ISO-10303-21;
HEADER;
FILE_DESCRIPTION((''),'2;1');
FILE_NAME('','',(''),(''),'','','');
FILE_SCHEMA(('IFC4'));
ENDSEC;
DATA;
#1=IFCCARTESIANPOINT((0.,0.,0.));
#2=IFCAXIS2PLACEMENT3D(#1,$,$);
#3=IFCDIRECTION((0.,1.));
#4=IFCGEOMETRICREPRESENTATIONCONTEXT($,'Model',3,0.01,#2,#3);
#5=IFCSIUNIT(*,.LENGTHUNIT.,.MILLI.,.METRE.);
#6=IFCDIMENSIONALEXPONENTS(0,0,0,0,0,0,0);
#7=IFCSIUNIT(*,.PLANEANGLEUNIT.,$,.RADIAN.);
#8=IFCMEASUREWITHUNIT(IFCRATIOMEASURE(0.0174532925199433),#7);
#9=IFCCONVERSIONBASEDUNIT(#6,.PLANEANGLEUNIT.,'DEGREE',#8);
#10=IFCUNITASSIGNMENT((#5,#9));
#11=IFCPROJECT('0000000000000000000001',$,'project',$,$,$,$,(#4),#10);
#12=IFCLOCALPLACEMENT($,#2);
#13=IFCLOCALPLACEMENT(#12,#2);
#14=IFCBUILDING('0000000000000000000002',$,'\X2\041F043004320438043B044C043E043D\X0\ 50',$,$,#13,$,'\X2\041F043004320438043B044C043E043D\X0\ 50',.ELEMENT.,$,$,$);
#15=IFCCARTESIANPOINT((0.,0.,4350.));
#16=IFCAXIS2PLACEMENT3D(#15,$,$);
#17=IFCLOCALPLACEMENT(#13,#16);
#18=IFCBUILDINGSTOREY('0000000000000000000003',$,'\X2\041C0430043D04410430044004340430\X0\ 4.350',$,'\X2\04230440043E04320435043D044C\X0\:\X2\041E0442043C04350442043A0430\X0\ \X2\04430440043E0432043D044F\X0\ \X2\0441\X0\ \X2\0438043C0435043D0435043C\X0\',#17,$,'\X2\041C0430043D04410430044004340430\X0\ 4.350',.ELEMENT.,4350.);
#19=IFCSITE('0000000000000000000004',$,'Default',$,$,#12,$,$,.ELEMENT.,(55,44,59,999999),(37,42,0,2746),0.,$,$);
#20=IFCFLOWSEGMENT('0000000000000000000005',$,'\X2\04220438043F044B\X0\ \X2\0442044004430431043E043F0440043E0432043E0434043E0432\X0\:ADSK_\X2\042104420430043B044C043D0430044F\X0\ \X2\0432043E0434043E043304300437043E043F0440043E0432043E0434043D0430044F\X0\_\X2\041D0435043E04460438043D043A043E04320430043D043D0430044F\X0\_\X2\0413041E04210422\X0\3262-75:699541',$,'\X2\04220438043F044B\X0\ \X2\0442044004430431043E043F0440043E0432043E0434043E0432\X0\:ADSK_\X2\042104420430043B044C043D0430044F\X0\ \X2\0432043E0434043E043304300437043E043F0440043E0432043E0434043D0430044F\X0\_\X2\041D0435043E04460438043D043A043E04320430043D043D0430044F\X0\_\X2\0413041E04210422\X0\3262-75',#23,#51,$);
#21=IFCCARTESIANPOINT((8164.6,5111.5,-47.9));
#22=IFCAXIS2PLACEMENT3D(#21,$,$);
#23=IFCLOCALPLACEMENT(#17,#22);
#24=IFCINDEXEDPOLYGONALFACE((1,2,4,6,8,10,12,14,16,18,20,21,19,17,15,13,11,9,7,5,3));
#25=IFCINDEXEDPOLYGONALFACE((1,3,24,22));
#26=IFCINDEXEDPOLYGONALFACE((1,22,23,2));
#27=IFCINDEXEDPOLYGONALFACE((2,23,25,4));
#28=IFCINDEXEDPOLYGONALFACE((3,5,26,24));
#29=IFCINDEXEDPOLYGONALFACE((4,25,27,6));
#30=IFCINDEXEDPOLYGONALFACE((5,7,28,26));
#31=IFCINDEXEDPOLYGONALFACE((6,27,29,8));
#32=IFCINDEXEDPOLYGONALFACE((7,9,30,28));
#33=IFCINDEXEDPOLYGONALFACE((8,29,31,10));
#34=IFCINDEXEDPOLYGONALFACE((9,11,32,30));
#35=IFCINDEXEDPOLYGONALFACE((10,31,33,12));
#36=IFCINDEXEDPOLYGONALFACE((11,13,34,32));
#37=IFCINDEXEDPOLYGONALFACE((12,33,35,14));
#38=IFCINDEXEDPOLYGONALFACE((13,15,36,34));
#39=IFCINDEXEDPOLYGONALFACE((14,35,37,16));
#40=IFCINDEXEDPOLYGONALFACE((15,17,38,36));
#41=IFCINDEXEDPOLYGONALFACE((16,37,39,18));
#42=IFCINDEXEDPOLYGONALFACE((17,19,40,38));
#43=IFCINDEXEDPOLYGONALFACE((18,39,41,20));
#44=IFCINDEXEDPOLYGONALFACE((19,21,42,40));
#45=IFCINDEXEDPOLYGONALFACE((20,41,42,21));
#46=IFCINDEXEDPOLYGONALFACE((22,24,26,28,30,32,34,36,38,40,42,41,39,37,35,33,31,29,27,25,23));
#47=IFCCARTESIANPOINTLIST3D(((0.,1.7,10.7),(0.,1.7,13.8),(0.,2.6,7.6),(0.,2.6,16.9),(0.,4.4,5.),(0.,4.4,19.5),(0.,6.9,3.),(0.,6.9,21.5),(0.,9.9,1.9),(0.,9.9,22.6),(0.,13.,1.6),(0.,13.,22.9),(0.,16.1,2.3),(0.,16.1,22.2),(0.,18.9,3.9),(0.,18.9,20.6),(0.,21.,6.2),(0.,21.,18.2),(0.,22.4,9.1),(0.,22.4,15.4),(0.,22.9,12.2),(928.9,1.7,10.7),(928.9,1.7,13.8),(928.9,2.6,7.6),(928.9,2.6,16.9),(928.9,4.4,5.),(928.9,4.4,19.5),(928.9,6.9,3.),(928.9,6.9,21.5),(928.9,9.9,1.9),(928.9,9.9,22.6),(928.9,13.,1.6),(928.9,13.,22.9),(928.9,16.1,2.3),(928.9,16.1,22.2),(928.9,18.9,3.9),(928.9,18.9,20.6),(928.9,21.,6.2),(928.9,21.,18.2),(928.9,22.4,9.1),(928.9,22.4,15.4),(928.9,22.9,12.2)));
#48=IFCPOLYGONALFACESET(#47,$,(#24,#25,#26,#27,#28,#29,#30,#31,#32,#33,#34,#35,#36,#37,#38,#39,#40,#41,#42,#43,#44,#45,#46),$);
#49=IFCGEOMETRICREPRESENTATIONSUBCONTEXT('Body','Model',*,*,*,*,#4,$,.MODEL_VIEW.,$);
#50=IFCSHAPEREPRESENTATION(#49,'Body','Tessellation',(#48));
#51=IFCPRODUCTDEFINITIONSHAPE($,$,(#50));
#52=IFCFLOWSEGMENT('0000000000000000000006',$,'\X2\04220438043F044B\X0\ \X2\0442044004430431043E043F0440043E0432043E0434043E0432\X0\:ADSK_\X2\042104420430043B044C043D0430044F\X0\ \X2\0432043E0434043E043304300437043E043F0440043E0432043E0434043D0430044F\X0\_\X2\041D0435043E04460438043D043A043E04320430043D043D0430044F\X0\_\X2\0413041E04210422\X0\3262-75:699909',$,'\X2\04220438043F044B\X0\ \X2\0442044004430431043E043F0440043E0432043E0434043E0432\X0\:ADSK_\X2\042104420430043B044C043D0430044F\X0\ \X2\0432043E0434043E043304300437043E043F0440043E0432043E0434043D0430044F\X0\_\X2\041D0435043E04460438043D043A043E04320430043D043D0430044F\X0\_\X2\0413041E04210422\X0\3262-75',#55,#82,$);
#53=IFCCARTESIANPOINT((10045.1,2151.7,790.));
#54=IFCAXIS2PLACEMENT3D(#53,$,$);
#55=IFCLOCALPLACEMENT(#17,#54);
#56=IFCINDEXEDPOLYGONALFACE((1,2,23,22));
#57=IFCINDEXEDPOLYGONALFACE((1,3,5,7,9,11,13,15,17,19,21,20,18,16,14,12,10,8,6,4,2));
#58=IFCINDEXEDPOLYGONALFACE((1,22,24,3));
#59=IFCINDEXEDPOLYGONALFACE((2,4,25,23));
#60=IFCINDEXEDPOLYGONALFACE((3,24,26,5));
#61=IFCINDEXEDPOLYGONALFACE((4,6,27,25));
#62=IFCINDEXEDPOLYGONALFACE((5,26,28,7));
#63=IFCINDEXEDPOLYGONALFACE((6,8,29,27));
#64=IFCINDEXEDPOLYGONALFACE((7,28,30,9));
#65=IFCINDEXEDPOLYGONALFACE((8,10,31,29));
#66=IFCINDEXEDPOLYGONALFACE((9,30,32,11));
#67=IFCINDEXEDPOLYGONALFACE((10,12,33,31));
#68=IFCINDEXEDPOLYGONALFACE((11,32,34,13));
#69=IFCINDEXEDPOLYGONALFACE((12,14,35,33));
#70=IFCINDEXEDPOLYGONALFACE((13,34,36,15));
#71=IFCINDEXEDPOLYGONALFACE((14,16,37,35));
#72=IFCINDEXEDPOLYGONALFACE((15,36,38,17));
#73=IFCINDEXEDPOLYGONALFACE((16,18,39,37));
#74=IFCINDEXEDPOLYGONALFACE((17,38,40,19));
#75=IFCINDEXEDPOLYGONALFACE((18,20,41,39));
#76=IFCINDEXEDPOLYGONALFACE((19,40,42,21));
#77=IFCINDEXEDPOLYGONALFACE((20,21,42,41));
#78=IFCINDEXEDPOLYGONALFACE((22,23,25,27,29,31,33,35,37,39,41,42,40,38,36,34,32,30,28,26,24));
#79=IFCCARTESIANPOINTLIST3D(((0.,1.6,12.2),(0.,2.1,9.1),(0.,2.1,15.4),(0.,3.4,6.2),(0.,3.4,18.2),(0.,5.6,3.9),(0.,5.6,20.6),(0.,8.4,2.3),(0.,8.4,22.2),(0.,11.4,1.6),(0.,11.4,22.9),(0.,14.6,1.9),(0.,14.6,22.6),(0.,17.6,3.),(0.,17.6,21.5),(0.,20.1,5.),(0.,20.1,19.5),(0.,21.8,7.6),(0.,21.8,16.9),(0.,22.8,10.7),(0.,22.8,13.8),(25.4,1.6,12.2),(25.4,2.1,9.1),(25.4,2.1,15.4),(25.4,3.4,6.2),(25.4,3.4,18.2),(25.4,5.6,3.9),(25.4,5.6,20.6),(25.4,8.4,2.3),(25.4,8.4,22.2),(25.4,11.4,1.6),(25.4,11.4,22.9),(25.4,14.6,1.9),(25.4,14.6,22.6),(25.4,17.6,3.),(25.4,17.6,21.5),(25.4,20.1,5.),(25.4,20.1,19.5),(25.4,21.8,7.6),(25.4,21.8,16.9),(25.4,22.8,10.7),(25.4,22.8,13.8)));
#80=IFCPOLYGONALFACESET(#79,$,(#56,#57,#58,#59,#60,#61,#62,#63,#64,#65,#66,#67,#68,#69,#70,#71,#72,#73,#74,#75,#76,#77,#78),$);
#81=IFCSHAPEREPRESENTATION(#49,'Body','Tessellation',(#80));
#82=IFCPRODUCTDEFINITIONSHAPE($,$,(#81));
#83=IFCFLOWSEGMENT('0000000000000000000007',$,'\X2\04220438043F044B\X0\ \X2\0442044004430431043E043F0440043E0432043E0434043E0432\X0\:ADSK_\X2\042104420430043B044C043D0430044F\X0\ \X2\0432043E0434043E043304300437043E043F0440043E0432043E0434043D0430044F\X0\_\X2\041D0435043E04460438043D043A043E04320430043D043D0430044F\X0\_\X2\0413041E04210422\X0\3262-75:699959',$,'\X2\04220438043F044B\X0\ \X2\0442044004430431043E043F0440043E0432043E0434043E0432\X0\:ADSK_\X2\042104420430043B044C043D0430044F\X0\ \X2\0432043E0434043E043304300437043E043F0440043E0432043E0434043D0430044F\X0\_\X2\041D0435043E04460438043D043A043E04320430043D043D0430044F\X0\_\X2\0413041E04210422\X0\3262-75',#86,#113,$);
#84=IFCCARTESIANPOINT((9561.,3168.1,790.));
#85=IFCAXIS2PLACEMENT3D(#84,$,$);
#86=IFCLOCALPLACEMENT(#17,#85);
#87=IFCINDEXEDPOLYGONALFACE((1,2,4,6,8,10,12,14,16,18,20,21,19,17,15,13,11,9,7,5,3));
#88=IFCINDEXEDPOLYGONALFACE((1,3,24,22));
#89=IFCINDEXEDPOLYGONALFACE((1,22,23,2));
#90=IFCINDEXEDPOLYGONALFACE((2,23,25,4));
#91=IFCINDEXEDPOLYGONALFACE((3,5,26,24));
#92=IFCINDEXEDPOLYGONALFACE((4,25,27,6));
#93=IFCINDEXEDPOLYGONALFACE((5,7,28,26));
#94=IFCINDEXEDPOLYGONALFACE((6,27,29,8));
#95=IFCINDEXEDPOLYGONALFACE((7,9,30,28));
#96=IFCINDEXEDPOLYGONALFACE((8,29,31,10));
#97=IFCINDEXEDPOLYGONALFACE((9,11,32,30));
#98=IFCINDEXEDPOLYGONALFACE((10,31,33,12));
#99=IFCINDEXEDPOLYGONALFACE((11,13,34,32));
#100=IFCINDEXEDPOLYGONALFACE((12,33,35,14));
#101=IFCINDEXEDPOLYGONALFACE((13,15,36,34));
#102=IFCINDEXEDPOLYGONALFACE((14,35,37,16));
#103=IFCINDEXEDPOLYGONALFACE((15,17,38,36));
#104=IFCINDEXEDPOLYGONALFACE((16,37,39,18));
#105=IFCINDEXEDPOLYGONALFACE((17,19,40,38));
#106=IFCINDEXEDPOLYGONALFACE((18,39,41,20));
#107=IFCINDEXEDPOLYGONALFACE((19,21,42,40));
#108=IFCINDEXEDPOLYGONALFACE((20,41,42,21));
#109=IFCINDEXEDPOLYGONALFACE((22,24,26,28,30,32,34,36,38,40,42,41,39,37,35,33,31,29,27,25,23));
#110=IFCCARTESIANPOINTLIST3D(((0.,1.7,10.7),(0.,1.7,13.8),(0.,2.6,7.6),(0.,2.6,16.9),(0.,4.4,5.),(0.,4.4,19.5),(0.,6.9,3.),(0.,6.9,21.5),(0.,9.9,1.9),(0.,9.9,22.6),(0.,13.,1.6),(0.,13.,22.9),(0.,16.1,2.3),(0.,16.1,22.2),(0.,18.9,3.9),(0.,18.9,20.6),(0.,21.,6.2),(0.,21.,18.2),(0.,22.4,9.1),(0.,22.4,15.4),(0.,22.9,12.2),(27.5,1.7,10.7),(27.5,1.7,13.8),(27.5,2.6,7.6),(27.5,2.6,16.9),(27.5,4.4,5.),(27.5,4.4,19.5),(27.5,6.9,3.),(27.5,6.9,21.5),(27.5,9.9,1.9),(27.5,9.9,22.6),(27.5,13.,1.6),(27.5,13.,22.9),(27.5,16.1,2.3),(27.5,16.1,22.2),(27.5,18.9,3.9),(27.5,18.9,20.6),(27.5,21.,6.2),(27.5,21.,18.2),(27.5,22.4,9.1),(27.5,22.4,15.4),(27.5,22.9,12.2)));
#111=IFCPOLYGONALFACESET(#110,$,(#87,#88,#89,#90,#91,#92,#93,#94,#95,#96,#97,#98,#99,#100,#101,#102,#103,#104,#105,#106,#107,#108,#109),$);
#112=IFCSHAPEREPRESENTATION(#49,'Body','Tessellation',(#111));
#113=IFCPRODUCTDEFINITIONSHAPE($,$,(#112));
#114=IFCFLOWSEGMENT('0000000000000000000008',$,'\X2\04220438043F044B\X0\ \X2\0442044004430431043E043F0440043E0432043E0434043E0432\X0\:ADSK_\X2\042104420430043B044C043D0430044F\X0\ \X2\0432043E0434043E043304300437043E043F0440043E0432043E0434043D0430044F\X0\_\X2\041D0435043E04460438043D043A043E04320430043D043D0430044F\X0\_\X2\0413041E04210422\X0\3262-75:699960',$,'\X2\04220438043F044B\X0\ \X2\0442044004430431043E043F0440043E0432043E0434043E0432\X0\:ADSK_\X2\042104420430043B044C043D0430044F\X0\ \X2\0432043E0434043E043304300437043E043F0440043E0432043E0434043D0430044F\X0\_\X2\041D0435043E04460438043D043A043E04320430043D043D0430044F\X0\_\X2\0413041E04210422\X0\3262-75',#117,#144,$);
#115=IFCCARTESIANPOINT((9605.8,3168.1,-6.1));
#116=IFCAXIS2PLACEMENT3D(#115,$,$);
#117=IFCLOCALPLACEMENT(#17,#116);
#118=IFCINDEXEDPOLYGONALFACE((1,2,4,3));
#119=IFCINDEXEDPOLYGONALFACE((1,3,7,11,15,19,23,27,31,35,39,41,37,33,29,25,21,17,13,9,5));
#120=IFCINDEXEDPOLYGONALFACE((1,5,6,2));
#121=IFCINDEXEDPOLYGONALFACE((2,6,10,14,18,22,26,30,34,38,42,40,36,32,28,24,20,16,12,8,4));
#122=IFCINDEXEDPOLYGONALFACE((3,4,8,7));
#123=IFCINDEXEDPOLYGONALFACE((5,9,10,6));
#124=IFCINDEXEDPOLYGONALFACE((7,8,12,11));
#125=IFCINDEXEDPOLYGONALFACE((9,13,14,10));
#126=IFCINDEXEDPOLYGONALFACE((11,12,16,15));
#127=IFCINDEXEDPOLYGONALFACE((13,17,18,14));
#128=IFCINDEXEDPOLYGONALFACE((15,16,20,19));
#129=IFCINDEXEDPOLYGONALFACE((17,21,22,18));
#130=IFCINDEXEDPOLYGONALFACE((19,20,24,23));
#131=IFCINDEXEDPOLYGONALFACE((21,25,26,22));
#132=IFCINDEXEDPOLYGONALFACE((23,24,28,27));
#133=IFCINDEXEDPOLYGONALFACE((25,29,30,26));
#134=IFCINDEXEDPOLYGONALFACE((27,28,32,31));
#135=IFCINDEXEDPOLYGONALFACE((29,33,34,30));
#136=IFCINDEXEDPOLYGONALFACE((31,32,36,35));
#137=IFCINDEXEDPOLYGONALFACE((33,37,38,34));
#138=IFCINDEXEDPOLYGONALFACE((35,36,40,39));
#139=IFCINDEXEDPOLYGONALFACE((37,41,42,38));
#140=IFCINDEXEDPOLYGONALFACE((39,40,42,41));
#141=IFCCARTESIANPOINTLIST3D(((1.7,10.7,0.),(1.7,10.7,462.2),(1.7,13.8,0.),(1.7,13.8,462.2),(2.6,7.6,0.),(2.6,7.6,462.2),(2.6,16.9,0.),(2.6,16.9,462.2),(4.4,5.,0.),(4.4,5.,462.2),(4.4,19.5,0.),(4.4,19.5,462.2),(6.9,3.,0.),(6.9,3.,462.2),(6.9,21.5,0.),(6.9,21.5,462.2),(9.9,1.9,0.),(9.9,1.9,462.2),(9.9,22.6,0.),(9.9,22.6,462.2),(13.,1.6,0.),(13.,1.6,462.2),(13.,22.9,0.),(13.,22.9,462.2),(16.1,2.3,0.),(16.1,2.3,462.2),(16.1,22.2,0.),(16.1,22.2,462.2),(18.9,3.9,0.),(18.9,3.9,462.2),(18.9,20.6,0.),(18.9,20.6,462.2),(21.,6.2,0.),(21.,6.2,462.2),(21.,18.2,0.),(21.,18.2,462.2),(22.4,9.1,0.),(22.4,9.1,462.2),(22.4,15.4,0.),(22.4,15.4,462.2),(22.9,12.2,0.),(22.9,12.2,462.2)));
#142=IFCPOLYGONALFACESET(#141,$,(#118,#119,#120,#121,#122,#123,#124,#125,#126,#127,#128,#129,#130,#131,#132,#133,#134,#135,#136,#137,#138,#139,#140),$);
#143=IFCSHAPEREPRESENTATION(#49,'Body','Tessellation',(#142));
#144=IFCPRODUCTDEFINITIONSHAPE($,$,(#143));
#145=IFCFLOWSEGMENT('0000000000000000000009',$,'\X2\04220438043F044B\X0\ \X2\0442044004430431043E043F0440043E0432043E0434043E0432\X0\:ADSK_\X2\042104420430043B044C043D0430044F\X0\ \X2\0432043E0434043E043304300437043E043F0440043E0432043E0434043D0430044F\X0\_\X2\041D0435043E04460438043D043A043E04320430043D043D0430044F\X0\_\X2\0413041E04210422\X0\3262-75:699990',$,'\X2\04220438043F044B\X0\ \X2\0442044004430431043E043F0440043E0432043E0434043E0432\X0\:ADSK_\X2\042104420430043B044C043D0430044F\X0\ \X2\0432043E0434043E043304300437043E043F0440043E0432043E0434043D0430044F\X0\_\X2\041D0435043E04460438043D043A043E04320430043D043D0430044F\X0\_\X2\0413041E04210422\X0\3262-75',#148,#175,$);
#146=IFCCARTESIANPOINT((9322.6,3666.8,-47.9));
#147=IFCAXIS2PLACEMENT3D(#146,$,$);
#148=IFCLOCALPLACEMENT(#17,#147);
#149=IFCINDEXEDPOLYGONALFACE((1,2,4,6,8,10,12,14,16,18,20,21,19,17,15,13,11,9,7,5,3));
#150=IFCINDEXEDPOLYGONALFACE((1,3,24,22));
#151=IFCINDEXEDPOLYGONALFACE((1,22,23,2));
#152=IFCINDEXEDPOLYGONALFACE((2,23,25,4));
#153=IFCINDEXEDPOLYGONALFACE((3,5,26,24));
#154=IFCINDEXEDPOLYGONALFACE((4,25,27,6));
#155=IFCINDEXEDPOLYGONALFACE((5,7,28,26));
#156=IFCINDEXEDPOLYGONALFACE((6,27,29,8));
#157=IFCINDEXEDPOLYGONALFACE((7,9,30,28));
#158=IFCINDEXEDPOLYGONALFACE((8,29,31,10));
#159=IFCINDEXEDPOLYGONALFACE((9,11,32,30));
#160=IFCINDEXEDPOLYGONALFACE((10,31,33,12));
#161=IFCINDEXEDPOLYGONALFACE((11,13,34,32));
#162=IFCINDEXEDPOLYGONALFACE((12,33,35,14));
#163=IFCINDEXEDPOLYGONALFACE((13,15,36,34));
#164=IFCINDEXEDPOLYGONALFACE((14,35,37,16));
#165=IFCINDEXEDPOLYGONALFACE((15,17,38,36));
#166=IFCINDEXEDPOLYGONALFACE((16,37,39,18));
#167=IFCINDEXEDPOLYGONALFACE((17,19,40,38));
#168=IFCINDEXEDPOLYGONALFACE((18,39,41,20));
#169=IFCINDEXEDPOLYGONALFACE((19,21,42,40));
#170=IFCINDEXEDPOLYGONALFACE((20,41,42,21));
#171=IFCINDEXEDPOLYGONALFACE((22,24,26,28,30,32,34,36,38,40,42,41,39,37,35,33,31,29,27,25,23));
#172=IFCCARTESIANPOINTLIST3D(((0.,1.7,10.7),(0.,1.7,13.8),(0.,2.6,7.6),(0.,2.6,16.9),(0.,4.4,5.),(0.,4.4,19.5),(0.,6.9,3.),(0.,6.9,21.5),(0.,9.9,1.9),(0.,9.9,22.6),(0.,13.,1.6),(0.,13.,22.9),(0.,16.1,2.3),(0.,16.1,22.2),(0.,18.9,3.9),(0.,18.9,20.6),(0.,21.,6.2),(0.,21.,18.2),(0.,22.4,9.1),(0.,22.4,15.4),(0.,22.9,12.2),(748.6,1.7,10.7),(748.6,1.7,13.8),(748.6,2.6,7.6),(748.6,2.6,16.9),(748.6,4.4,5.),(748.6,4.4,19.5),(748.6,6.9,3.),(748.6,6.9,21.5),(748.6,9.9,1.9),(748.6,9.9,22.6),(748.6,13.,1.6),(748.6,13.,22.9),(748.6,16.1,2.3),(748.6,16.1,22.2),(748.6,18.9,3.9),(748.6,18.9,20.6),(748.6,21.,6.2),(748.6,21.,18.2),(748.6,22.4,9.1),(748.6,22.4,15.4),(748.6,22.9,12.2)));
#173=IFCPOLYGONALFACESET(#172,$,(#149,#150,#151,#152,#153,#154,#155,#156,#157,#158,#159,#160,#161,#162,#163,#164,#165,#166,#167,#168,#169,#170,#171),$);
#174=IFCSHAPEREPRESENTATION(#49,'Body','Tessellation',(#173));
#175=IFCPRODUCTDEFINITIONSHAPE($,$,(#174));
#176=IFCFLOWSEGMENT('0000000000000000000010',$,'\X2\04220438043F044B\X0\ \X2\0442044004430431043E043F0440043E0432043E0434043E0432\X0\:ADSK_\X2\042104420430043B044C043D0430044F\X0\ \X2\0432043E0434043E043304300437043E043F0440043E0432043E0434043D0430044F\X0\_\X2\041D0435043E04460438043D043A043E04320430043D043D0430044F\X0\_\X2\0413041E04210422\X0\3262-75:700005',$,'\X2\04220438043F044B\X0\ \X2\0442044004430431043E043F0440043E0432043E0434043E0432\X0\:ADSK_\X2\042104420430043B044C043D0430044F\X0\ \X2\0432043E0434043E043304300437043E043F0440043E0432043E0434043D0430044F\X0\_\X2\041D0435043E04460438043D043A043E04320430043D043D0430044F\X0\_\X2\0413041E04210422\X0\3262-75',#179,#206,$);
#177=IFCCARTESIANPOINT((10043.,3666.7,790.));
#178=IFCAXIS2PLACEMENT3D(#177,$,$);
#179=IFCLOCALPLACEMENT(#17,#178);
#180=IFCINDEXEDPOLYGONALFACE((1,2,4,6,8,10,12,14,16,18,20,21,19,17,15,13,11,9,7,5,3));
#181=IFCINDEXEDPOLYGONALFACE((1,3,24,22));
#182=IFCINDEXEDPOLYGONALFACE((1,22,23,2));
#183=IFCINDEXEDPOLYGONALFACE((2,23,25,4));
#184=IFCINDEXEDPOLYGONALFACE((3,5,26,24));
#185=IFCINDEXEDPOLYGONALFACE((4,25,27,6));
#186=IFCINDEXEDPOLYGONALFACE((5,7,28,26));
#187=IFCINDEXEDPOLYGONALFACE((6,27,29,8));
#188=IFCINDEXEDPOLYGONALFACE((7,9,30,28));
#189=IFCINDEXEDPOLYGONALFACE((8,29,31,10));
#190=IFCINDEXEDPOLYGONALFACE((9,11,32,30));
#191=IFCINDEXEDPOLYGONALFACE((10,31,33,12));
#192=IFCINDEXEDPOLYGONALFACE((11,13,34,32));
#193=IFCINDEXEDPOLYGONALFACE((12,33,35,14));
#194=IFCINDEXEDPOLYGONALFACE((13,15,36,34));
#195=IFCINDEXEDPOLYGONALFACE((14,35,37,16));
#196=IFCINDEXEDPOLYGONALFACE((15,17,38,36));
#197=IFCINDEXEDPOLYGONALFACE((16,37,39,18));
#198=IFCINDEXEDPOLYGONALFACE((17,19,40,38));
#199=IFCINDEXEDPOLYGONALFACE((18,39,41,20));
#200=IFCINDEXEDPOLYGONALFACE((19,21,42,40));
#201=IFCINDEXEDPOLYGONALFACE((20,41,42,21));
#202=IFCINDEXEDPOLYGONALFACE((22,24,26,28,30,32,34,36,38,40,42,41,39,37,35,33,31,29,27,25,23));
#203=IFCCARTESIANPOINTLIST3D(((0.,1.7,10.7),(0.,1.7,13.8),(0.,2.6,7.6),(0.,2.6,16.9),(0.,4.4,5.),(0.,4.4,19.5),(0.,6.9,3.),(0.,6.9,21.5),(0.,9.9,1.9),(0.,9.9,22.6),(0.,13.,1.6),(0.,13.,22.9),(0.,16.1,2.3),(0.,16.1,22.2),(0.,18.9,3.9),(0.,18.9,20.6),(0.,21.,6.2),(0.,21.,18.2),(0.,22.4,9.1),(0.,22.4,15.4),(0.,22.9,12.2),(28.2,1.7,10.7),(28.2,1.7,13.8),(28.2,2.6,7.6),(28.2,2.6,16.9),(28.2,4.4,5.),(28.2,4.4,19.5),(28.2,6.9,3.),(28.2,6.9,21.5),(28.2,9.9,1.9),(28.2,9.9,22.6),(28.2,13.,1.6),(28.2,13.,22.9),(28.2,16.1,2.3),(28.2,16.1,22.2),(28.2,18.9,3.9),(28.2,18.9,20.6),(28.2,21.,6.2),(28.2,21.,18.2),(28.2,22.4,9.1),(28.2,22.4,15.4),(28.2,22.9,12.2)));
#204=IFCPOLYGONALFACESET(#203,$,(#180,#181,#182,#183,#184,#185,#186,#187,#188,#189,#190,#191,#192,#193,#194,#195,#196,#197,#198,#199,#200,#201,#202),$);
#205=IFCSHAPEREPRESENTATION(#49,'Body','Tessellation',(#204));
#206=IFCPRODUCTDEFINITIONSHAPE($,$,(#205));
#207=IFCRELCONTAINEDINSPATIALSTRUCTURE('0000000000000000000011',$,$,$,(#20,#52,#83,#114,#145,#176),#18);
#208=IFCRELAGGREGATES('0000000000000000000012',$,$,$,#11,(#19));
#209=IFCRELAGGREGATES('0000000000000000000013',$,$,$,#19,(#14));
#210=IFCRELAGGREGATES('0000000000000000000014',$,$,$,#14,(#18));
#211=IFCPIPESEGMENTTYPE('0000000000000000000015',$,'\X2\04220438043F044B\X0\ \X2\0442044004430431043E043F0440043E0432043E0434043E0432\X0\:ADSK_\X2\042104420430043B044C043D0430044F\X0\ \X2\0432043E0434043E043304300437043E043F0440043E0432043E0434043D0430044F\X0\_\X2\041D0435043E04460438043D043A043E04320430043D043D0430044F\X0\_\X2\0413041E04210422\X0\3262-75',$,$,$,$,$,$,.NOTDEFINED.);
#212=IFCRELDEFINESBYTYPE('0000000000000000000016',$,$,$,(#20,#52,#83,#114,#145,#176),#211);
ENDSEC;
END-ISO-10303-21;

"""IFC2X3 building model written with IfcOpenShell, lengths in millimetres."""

from ifc_helpers import new_model, entity, si_unit, converted_unit, direction, frame, origin, origin_2d_with_axis, place, context, subcontext, project, spatial, circle, extrude, type_object, element, save


model = new_model("IFC2X3")

# Units and contexts
model_context = context("Model", 3, precision=0.01, world=origin(), true_north=direction((0.0, 1.0)))
body_context = subcontext(model_context, "Body", "Model", "MODEL_VIEW")
ifc_project = project(units=[si_unit("LENGTHUNIT", "METRE", prefix="MILLI"), converted_unit("PLANEANGLEUNIT", "DEGREE", entity("IfcRatioMeasure", 0.0174532925199433), si_unit("PLANEANGLEUNIT", "RADIAN"), dimensions=[0, 0, 0, 0, 0, 0, 0])], contexts=[model_context])

# Site, building, storey
site_placement = place(None, origin())
site = spatial("IfcSite", under=ifc_project, at=site_placement, Name="Default", CompositionType="ELEMENT", RefLatitude=(55, 44, 59, 999999), RefLongitude=(37, 42, 0, 2746), RefElevation=0.0)
building_placement = place(site_placement, origin())
building = spatial("IfcBuilding", under=site, at=building_placement, Name="Павильон 50", LongName="Павильон 50", CompositionType="ELEMENT")
storey_placement = place(building_placement, frame((0.0, 0.0, 4350.0)))
storey = spatial("IfcBuildingStorey", under=building, at=storey_placement, Name="Мансарда 4.350", ObjectType="Уровень:Отметка уровня с именем", LongName="Мансарда 4.350", CompositionType="ELEMENT", Elevation=4350.0)

# Flow segments
pipe_segment_type = type_object("IfcPipeSegmentType", Name="Типы трубопроводов:ADSK_Стальная водогазопроводная_Неоцинкованная_ГОСТ3262-75", PredefinedType="NOTDEFINED")
flow_segment_1_placement = place(storey_placement, frame((8164.6, 5111.5, -47.9)))
element("IfcFlowSegment", 1, at=flow_segment_1_placement, inside=storey, type_object=pipe_segment_type, Name="Типы трубопроводов:ADSK_Стальная водогазопроводная_Неоцинкованная_ГОСТ3262-75:699541", ObjectType="Типы трубопроводов:ADSK_Стальная водогазопроводная_Неоцинкованная_ГОСТ3262-75", context=body_context, shape_type="SweptSolid", body=[
    extrude(circle(Radius=10.7, at=origin_2d_with_axis()), frame((0.0, 12.2, 12.2), z_axis=(1.0, 0.0, 0.0), x_axis=(0.0, 1.0, 0.0)), (0.0, 0.0, 1.0), 928.9),
])
flow_segment_2_placement = place(storey_placement, frame((10045.1, 2151.7, 790.0)))
element("IfcFlowSegment", 2, at=flow_segment_2_placement, inside=storey, type_object=pipe_segment_type, Name="Типы трубопроводов:ADSK_Стальная водогазопроводная_Неоцинкованная_ГОСТ3262-75:699909", ObjectType="Типы трубопроводов:ADSK_Стальная водогазопроводная_Неоцинкованная_ГОСТ3262-75", context=body_context, shape_type="SweptSolid", body=[
    extrude(circle(Radius=10.7, at=origin_2d_with_axis()), frame((0.0, 12.2, 12.2), z_axis=(1.0, 0.0, 0.0), x_axis=(0.0, -1.0, 0.0)), (0.0, 0.0, 1.0), 25.4),
])
flow_segment_3_placement = place(storey_placement, frame((9561.0, 3168.1, 790.0)))
element("IfcFlowSegment", 3, at=flow_segment_3_placement, inside=storey, type_object=pipe_segment_type, Name="Типы трубопроводов:ADSK_Стальная водогазопроводная_Неоцинкованная_ГОСТ3262-75:699959", ObjectType="Типы трубопроводов:ADSK_Стальная водогазопроводная_Неоцинкованная_ГОСТ3262-75", context=body_context, shape_type="SweptSolid", body=[
    extrude(circle(Radius=10.7, at=origin_2d_with_axis()), frame((0.0, 12.2, 12.2), z_axis=(1.0, 0.0, 0.0), x_axis=(0.0, 1.0, 0.0)), (0.0, 0.0, 1.0), 27.5),
])
flow_segment_4_placement = place(storey_placement, frame((9605.8, 3168.1, -6.1)))
element("IfcFlowSegment", 4, at=flow_segment_4_placement, inside=storey, type_object=pipe_segment_type, Name="Типы трубопроводов:ADSK_Стальная водогазопроводная_Неоцинкованная_ГОСТ3262-75:699960", ObjectType="Типы трубопроводов:ADSK_Стальная водогазопроводная_Неоцинкованная_ГОСТ3262-75", context=body_context, shape_type="SweptSolid", body=[
    extrude(circle(Radius=10.7, at=origin_2d_with_axis()), frame((12.2, 12.2, 0.0)), (0.0, 0.0, 1.0), 462.2),
])
flow_segment_5_placement = place(storey_placement, frame((9322.6, 3666.8, -47.9)))
element("IfcFlowSegment", 5, at=flow_segment_5_placement, inside=storey, type_object=pipe_segment_type, Name="Типы трубопроводов:ADSK_Стальная водогазопроводная_Неоцинкованная_ГОСТ3262-75:699990", ObjectType="Типы трубопроводов:ADSK_Стальная водогазопроводная_Неоцинкованная_ГОСТ3262-75", context=body_context, shape_type="SweptSolid", body=[
    extrude(circle(Radius=10.7, at=origin_2d_with_axis()), frame((0.0, 12.2, 12.2), z_axis=(1.0, 0.0, 0.0), x_axis=(0.0, 1.0, 0.0)), (0.0, 0.0, 1.0), 748.6),
])
flow_segment_6_placement = place(storey_placement, frame((10043.0, 3666.7, 790.0)))
element("IfcFlowSegment", 6, at=flow_segment_6_placement, inside=storey, type_object=pipe_segment_type, Name="Типы трубопроводов:ADSK_Стальная водогазопроводная_Неоцинкованная_ГОСТ3262-75:700005", ObjectType="Типы трубопроводов:ADSK_Стальная водогазопроводная_Неоцинкованная_ГОСТ3262-75", context=body_context, shape_type="SweptSolid", body=[
    extrude(circle(Radius=10.7, at=origin_2d_with_axis()), frame((0.0, 12.2, 12.2), z_axis=(1.0, 0.0, 0.0), x_axis=(0.0, 1.0, 0.0)), (0.0, 0.0, 1.0), 28.2),
])

save(model, "model.ifc")
